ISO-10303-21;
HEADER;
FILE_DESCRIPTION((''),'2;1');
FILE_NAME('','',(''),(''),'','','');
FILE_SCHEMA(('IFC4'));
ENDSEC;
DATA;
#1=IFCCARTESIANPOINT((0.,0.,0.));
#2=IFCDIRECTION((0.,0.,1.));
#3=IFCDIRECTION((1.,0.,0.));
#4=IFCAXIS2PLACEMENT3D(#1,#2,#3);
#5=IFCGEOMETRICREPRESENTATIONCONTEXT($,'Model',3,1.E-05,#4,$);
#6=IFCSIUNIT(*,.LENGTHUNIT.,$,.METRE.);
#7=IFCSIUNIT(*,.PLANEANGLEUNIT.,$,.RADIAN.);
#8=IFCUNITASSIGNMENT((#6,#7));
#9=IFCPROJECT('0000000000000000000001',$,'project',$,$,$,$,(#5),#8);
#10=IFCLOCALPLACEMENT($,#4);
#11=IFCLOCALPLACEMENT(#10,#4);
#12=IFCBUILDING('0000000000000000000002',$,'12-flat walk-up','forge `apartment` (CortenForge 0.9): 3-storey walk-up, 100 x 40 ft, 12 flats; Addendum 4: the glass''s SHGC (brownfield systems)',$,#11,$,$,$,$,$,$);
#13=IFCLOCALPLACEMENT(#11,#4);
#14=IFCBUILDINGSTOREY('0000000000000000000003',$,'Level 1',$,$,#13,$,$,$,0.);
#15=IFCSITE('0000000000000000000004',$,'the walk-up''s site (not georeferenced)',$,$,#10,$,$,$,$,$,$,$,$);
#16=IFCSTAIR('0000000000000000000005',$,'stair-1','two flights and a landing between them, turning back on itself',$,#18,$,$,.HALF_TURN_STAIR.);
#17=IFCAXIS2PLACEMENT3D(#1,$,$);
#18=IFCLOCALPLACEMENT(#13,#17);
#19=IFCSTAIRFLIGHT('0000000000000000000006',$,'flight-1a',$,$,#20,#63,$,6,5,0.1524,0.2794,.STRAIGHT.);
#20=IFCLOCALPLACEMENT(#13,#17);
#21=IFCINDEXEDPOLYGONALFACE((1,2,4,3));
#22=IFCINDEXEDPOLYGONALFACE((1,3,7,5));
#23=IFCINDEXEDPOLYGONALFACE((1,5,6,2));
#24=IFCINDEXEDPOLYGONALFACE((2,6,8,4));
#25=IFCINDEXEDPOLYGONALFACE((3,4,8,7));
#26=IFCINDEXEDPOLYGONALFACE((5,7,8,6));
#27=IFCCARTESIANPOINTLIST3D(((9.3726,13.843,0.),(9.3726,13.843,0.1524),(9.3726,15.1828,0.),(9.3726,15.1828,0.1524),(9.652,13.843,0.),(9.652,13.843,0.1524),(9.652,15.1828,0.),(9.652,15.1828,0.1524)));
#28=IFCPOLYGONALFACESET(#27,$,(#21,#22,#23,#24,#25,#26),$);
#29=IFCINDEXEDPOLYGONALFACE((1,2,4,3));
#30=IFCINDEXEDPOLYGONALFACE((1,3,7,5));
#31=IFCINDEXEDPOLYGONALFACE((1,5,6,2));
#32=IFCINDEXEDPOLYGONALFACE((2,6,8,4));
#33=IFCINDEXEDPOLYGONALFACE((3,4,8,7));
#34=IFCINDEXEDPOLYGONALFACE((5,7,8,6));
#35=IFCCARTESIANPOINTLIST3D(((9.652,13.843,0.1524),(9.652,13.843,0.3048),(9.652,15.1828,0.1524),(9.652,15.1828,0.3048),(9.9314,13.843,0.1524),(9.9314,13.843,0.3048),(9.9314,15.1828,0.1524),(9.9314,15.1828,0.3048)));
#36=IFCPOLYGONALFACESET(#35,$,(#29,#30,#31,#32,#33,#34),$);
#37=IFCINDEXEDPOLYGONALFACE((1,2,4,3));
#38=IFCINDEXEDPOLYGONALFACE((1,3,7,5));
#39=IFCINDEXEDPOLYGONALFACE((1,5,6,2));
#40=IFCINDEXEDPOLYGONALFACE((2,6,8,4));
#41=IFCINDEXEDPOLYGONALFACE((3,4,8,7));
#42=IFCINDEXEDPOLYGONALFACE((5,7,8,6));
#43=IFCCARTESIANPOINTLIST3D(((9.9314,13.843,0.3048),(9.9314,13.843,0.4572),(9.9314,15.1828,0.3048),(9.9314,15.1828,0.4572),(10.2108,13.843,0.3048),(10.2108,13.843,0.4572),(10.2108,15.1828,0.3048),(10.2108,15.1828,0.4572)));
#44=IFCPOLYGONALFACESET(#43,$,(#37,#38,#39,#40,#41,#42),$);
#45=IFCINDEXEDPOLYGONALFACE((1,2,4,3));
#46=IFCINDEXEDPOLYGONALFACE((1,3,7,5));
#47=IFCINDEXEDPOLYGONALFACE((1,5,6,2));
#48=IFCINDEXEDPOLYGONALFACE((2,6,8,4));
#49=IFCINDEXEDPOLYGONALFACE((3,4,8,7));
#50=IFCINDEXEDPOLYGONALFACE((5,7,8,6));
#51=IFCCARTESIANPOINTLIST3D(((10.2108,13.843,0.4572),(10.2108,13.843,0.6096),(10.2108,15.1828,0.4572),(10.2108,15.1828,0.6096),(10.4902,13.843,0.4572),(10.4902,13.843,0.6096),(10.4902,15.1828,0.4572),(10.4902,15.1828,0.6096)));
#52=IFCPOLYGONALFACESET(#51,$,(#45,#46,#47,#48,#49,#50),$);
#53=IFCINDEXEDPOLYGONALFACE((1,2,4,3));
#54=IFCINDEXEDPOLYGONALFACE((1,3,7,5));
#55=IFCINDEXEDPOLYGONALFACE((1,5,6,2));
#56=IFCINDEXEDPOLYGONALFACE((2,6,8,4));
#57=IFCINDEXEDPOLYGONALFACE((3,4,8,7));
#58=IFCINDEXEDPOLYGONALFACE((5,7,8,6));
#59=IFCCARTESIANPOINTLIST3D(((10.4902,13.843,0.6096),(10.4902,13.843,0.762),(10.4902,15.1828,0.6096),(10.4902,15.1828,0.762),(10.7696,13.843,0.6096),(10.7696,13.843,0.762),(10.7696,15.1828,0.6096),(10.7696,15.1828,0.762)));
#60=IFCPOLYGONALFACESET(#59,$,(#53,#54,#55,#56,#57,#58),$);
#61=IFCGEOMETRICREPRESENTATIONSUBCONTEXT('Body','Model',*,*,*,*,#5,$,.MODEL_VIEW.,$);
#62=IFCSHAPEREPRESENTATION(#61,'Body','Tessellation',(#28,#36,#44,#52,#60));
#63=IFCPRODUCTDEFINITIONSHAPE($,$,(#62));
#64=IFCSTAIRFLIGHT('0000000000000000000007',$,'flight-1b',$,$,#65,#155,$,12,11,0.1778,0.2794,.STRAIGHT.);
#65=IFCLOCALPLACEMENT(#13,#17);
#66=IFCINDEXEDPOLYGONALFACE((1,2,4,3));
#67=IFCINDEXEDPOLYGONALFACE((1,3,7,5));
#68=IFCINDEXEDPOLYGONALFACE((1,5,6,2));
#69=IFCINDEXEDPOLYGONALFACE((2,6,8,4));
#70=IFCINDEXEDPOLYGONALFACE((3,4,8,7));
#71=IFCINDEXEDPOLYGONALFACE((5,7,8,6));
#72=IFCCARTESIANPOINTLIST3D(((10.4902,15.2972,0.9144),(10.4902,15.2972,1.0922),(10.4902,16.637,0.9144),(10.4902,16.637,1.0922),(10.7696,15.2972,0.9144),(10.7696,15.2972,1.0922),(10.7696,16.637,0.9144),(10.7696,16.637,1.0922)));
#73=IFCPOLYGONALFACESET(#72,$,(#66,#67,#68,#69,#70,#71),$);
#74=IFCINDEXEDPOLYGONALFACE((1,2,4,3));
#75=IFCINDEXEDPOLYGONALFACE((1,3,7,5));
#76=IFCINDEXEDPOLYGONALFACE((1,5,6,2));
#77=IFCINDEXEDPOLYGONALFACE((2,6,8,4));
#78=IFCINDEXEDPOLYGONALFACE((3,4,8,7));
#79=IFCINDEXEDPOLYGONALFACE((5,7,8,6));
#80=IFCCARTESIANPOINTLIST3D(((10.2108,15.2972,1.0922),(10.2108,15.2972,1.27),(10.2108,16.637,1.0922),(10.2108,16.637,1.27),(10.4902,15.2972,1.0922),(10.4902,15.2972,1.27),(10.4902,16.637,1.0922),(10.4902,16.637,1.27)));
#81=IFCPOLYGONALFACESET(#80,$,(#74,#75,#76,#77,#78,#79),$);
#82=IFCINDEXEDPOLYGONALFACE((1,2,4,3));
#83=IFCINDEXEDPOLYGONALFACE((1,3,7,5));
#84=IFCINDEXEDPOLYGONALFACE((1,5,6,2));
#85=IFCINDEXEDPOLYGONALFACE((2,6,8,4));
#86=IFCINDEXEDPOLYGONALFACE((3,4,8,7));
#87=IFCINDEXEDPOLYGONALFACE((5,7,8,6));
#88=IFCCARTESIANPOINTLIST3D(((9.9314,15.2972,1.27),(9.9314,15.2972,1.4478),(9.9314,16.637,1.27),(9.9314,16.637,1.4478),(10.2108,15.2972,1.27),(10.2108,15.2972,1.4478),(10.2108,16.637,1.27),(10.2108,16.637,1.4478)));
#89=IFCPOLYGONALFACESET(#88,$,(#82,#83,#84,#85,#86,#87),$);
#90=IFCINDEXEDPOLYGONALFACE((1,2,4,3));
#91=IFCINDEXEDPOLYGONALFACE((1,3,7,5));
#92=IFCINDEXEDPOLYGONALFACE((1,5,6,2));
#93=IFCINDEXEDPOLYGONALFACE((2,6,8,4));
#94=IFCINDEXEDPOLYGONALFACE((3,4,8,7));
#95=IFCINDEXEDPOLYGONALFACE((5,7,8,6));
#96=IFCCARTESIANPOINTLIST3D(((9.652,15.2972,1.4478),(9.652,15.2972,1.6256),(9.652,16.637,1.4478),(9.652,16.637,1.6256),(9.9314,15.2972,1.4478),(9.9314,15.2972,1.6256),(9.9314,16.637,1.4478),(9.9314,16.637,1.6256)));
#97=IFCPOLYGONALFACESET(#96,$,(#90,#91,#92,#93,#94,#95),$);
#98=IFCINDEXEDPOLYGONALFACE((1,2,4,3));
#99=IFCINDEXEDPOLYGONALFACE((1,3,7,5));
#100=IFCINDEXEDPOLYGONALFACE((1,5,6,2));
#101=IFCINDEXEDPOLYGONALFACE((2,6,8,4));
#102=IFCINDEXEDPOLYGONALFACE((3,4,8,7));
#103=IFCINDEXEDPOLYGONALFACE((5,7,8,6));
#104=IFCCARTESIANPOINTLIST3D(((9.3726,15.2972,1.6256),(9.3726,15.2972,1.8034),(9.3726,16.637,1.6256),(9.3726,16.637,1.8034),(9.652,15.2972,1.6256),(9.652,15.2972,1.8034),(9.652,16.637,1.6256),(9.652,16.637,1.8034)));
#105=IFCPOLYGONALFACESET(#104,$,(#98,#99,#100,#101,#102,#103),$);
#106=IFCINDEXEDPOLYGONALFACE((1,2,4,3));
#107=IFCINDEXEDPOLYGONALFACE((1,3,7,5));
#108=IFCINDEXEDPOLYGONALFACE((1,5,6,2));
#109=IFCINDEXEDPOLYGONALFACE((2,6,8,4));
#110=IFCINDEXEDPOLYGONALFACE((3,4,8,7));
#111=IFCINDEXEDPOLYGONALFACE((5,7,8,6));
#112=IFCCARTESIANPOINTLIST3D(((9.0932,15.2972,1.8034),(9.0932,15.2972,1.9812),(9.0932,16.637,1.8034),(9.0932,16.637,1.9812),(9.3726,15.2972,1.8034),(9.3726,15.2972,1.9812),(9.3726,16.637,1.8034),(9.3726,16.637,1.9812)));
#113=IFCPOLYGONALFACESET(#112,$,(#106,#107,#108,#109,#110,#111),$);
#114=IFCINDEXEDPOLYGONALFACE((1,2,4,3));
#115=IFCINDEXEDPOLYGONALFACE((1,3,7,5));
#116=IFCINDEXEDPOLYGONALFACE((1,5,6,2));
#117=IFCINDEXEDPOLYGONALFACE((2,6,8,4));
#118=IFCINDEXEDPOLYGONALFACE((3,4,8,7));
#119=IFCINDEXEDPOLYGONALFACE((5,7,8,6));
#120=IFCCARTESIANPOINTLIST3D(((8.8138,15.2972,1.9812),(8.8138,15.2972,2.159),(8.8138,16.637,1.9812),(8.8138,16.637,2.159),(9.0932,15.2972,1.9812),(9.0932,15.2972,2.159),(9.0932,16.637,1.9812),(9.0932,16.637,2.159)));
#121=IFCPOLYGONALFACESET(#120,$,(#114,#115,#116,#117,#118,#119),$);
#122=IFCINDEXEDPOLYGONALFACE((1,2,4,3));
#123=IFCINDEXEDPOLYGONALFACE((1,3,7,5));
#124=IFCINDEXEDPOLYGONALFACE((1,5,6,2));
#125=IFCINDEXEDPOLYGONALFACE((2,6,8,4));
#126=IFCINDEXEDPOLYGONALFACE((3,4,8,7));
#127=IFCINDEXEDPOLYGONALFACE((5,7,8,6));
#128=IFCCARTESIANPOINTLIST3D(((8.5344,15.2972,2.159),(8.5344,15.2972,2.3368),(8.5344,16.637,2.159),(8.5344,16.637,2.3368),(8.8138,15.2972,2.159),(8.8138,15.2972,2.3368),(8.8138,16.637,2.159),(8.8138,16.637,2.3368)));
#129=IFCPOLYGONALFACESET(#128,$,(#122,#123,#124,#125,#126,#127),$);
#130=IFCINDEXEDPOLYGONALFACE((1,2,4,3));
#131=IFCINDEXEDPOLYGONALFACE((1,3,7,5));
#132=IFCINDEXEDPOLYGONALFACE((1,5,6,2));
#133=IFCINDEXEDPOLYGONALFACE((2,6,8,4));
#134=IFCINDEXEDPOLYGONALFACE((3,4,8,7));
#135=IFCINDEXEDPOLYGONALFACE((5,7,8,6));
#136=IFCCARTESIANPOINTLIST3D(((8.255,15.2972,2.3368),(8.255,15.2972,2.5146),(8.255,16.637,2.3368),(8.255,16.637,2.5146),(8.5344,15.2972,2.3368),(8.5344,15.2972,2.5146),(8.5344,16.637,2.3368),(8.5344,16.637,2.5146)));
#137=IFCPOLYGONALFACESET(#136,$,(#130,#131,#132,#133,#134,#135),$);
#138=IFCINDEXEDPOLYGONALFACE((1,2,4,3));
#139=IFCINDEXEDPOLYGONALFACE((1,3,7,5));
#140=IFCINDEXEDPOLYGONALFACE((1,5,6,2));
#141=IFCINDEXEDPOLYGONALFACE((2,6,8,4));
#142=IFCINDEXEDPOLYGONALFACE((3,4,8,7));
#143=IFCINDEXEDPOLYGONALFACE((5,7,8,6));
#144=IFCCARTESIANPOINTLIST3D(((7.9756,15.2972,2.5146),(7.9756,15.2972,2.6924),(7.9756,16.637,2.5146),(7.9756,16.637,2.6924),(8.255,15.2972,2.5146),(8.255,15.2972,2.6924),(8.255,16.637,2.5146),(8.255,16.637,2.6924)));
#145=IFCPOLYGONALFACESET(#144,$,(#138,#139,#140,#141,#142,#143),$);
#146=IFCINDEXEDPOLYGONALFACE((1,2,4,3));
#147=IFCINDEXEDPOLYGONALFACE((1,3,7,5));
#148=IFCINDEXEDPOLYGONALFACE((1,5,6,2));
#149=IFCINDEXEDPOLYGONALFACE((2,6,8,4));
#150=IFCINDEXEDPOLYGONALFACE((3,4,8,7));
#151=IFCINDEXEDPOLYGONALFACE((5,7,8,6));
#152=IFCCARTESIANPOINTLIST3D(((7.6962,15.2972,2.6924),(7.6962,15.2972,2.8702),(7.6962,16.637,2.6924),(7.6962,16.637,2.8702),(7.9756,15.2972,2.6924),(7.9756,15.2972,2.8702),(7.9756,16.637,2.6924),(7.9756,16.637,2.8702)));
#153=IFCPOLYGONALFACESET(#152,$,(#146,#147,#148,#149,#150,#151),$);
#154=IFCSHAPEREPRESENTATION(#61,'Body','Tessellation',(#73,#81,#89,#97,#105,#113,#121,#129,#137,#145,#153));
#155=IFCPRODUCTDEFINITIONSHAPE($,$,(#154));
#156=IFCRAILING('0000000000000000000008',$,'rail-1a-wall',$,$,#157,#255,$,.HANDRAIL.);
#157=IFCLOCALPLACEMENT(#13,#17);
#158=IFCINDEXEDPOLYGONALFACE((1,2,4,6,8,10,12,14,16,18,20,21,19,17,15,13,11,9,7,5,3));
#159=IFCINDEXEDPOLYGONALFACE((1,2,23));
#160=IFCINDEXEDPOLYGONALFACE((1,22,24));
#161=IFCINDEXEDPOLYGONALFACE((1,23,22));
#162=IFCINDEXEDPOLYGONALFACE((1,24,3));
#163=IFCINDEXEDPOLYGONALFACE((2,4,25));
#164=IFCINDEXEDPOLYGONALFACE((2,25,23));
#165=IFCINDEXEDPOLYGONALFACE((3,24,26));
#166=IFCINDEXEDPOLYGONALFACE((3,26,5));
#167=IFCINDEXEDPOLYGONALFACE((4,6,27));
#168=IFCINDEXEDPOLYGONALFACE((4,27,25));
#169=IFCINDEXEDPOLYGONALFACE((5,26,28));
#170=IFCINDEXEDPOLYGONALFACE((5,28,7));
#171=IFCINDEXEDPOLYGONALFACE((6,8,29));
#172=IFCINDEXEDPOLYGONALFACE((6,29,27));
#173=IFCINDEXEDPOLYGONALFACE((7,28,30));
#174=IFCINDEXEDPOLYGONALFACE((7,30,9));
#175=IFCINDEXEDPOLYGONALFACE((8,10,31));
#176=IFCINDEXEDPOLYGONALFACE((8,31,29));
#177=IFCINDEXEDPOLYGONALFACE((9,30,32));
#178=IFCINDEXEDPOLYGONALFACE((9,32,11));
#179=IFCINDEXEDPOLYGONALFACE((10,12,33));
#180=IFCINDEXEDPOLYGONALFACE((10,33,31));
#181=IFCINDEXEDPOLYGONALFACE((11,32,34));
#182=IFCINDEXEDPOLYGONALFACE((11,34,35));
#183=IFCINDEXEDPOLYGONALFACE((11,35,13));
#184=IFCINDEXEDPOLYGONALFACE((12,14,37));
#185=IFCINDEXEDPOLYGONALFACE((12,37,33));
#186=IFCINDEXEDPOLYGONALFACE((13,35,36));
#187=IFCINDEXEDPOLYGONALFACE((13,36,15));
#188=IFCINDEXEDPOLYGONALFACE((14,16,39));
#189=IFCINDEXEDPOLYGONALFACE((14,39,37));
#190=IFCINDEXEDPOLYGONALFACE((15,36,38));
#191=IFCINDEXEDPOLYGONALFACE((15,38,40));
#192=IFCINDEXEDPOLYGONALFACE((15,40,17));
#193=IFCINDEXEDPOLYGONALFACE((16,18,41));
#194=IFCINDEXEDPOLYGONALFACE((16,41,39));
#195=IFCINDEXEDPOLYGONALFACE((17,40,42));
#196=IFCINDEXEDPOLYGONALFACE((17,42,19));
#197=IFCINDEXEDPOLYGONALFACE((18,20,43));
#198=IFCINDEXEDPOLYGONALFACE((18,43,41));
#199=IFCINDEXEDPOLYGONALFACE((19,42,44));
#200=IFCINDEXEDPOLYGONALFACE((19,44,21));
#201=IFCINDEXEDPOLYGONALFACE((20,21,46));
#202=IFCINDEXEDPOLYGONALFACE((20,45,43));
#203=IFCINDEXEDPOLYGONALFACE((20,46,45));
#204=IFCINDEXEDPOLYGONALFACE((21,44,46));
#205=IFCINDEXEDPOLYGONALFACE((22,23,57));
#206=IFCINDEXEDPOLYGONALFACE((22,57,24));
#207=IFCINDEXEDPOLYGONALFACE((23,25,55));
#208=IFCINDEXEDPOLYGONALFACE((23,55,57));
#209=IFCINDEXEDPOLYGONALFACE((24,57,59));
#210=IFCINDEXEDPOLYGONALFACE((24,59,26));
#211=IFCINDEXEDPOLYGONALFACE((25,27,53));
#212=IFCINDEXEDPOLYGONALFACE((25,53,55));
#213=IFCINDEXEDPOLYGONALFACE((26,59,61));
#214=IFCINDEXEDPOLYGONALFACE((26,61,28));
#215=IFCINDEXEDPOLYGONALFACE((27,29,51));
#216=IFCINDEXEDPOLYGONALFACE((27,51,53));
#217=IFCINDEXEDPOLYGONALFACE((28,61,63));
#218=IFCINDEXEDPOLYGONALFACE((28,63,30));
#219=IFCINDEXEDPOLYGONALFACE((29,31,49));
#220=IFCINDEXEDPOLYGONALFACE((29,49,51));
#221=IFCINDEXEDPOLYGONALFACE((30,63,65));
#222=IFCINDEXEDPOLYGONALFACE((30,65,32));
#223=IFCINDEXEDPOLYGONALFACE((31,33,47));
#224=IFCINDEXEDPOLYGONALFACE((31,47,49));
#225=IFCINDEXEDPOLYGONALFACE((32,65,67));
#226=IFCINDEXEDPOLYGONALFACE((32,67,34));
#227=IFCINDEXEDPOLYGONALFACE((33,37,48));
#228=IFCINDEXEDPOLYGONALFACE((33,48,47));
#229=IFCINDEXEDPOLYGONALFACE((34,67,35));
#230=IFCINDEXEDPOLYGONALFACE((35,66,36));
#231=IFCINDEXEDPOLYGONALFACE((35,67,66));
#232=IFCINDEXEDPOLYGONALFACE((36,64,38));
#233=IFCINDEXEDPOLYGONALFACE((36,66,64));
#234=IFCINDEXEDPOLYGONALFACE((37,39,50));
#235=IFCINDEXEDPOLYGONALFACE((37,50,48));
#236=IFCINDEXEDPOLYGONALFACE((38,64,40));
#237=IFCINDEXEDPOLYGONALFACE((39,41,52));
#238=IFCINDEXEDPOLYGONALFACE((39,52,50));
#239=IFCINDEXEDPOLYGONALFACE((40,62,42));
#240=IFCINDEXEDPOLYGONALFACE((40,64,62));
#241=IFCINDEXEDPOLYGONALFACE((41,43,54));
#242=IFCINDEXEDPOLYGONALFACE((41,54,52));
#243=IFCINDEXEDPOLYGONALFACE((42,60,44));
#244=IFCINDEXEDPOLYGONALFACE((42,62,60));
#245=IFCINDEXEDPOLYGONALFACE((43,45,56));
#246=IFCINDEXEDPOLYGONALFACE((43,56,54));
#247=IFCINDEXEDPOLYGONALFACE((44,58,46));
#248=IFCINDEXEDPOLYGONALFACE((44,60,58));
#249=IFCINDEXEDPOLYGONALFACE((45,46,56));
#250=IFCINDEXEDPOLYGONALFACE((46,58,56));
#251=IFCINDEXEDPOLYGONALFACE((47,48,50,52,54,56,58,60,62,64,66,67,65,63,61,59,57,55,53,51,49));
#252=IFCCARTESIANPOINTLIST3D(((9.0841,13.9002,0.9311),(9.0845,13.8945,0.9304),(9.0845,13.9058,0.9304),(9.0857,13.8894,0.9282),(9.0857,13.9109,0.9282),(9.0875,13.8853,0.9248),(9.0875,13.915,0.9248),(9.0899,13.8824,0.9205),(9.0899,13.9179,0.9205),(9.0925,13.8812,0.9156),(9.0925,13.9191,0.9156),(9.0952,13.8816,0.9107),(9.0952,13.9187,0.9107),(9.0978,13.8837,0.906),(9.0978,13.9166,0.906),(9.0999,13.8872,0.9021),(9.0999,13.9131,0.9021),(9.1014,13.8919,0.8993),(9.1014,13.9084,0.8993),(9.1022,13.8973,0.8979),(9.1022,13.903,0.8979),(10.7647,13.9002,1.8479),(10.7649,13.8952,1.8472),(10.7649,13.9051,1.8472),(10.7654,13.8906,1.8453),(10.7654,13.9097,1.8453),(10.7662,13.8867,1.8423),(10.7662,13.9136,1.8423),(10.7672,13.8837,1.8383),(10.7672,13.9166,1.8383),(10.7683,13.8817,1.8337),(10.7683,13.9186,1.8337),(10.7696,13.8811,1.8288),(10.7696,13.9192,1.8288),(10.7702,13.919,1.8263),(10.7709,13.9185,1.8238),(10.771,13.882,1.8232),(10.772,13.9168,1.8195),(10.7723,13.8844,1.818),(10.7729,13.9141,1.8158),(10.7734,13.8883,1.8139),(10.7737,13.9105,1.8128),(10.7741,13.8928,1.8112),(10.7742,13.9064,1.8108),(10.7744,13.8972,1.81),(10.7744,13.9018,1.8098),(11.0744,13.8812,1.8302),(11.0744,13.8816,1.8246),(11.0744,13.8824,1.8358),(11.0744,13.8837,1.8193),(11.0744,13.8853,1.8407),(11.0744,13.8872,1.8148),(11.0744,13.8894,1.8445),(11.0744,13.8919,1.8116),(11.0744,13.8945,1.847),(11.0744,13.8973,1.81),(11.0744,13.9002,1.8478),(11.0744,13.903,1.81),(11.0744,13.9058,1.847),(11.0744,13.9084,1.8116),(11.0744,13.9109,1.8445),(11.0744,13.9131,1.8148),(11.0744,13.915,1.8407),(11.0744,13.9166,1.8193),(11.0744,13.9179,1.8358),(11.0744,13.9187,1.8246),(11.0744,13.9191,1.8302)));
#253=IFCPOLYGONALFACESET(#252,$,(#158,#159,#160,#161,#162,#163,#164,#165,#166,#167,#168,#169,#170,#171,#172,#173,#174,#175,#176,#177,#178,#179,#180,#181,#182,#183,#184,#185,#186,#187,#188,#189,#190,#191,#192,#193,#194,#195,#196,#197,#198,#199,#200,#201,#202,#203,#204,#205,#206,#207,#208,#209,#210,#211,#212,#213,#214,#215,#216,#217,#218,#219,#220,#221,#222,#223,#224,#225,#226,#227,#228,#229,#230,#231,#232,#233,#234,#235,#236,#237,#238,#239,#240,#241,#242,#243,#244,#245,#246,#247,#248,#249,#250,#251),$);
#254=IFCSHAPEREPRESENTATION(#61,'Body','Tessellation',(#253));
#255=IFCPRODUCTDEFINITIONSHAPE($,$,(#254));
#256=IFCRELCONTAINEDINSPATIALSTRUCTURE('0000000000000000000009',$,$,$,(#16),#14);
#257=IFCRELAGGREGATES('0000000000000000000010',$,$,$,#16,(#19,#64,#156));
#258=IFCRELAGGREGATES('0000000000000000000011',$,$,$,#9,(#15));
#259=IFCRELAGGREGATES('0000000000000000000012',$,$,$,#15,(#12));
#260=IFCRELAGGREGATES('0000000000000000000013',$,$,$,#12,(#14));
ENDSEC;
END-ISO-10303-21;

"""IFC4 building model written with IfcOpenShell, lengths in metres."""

from ifc_helpers import new_model, entity, si_unit, frame, frame_2d, origin, origin_with_axes, place, context, subcontext, project, spatial, rectangle, extrude, element, aggregate, save


model = new_model("IFC4")

# Units and contexts
model_context = context("Model", 3, precision=1e-05, world=origin_with_axes())
body_context = subcontext(model_context, "Body", "Model", "MODEL_VIEW")
ifc_project = project(units=[si_unit("LENGTHUNIT", "METRE"), si_unit("PLANEANGLEUNIT", "RADIAN")], contexts=[model_context])

# Site, building, storey
site_placement = place(None, origin_with_axes())
site = spatial("IfcSite", under=ifc_project, at=site_placement, Name="the walk-up's site (not georeferenced)")
building_placement = place(site_placement, origin_with_axes())
building = spatial("IfcBuilding", under=site, at=building_placement, Name="12-flat walk-up", Description="forge `apartment` (CortenForge 0.9): 3-storey walk-up, 100 x 40 ft, 12 flats; Addendum 4: the glass's SHGC (brownfield systems)")
storey_placement = place(building_placement, origin_with_axes())
storey = spatial("IfcBuildingStorey", under=building, at=storey_placement, Name="Level 1", Elevation=0.0)

# Stair, stair flights, railing
stair_placement = place(storey_placement, origin_with_axes())
stair = element("IfcStair", 1, at=stair_placement, inside=storey, Name="stair-1", Description="two flights and a landing between them, turning back on itself", PredefinedType="HALF_TURN_STAIR")
stair_flight_1_placement = place(stair_placement, frame((9.3726, 13.843, 0.0), z_axis=(0.0, 0.0, 1.0), x_axis=(1.0, 0.0, 0.0)))
stair_flight_1 = element("IfcStairFlight", 2, at=stair_flight_1_placement, Name="flight-1a", NumberOfRisers=6, NumberOfTreads=5, PredefinedType="STRAIGHT", RiserHeight=0.1524, TreadLength=0.2794, context=body_context, shape_type="SweptSolid", body=[
    extrude(rectangle(XDim=0.2794, YDim=1.3399, at=frame_2d((0.1397, 0.6699))), origin(), (0.0, 0.0, 1.0), 0.1524),
    extrude(rectangle(XDim=0.2794, YDim=1.3399, at=frame_2d((0.1397, 0.6699))), frame((0.2794, 0.0, 0.1524)), (0.0, 0.0, 1.0), 0.1524),
    extrude(rectangle(XDim=0.2794, YDim=1.3399, at=frame_2d((0.1397, 0.6699))), frame((0.5588, 0.0, 0.3048)), (0.0, 0.0, 1.0), 0.1524),
    extrude(rectangle(XDim=0.2794, YDim=1.3399, at=frame_2d((0.1397, 0.6699))), frame((0.8382, 0.0, 0.4572)), (0.0, 0.0, 1.0), 0.1524),
    extrude(rectangle(XDim=0.2794, YDim=1.3399, at=frame_2d((0.1397, 0.6699))), frame((1.1176, 0.0, 0.6096)), (0.0, 0.0, 1.0), 0.1524),
])
stair_flight_2_placement = place(stair_placement, frame((7.6962, 15.2972, 0.9144), z_axis=(0.0, 0.0, 1.0), x_axis=(1.0, 0.0, 0.0)))
stair_flight_2 = element("IfcStairFlight", 3, at=stair_flight_2_placement, Name="flight-1b", NumberOfRisers=12, NumberOfTreads=11, PredefinedType="STRAIGHT", RiserHeight=0.1778, TreadLength=0.2794, context=body_context, shape_type="SweptSolid", body=[
    extrude(rectangle(XDim=0.2794, YDim=1.3399, at=frame_2d((0.1397, 0.6699))), frame((2.794, 0.0, 0.0)), (0.0, 0.0, 1.0), 0.1778),
    extrude(rectangle(XDim=0.2794, YDim=1.3399, at=frame_2d((0.1397, 0.6699))), frame((2.5146, 0.0, 0.1778)), (0.0, 0.0, 1.0), 0.1778),
    extrude(rectangle(XDim=0.2794, YDim=1.3399, at=frame_2d((0.1397, 0.6699))), frame((2.2352, 0.0, 0.3556)), (0.0, 0.0, 1.0), 0.1778),
    extrude(rectangle(XDim=0.2794, YDim=1.3399, at=frame_2d((0.1397, 0.6699))), frame((1.9558, 0.0, 0.5334)), (0.0, 0.0, 1.0), 0.1778),
    extrude(rectangle(XDim=0.2794, YDim=1.3399, at=frame_2d((0.1397, 0.6699))), frame((1.6764, 0.0, 0.7112)), (0.0, 0.0, 1.0), 0.1778),
    extrude(rectangle(XDim=0.2794, YDim=1.3399, at=frame_2d((0.1397, 0.6699))), frame((1.397, 0.0, 0.889)), (0.0, 0.0, 1.0), 0.1778),
    extrude(rectangle(XDim=0.2794, YDim=1.3399, at=frame_2d((0.1397, 0.6699))), frame((1.1176, 0.0, 1.0668)), (0.0, 0.0, 1.0), 0.1778),
    extrude(rectangle(XDim=0.2794, YDim=1.3399, at=frame_2d((0.1397, 0.6699))), frame((0.8382, 0.0, 1.2446)), (0.0, 0.0, 1.0), 0.1778),
    extrude(rectangle(XDim=0.2794, YDim=1.3399, at=frame_2d((0.1397, 0.6699))), frame((0.5588, 0.0, 1.4224)), (0.0, 0.0, 1.0), 0.1778),
    extrude(rectangle(XDim=0.2794, YDim=1.3399, at=frame_2d((0.1397, 0.6699))), frame((0.2794, 0.0, 1.6002)), (0.0, 0.0, 1.0), 0.1778),
    extrude(rectangle(XDim=0.2794, YDim=1.3399, at=frame_2d((0.1397, 0.6699))), frame((0.0, 0.0, 1.778)), (0.0, 0.0, 1.0), 0.1778),
])
railing_1_placement = place(stair_placement, frame((9.0932, 13.9002, 0.9144), z_axis=(0.0, 0.0, 1.0), x_axis=(1.0, 0.0, 0.0)))
railing_1 = element("IfcRailing", 4, at=railing_1_placement, Name="rail-1a-wall", PredefinedType="HANDRAIL", context=body_context, shape_type="AdvancedSweptSolid", body=[
    entity("IfcSweptDiskSolid", entity("IfcPolyline", [entity("IfcCartesianPoint", [0.0, 0.0, 0.0]), entity("IfcCartesianPoint", [1.6764, 0.0, 0.9144]), entity("IfcCartesianPoint", [1.9812, 0.0, 0.9144])]), 0.0191),
])
aggregate(stair, [stair_flight_1, stair_flight_2, railing_1])

save(model, "model.ifc")
